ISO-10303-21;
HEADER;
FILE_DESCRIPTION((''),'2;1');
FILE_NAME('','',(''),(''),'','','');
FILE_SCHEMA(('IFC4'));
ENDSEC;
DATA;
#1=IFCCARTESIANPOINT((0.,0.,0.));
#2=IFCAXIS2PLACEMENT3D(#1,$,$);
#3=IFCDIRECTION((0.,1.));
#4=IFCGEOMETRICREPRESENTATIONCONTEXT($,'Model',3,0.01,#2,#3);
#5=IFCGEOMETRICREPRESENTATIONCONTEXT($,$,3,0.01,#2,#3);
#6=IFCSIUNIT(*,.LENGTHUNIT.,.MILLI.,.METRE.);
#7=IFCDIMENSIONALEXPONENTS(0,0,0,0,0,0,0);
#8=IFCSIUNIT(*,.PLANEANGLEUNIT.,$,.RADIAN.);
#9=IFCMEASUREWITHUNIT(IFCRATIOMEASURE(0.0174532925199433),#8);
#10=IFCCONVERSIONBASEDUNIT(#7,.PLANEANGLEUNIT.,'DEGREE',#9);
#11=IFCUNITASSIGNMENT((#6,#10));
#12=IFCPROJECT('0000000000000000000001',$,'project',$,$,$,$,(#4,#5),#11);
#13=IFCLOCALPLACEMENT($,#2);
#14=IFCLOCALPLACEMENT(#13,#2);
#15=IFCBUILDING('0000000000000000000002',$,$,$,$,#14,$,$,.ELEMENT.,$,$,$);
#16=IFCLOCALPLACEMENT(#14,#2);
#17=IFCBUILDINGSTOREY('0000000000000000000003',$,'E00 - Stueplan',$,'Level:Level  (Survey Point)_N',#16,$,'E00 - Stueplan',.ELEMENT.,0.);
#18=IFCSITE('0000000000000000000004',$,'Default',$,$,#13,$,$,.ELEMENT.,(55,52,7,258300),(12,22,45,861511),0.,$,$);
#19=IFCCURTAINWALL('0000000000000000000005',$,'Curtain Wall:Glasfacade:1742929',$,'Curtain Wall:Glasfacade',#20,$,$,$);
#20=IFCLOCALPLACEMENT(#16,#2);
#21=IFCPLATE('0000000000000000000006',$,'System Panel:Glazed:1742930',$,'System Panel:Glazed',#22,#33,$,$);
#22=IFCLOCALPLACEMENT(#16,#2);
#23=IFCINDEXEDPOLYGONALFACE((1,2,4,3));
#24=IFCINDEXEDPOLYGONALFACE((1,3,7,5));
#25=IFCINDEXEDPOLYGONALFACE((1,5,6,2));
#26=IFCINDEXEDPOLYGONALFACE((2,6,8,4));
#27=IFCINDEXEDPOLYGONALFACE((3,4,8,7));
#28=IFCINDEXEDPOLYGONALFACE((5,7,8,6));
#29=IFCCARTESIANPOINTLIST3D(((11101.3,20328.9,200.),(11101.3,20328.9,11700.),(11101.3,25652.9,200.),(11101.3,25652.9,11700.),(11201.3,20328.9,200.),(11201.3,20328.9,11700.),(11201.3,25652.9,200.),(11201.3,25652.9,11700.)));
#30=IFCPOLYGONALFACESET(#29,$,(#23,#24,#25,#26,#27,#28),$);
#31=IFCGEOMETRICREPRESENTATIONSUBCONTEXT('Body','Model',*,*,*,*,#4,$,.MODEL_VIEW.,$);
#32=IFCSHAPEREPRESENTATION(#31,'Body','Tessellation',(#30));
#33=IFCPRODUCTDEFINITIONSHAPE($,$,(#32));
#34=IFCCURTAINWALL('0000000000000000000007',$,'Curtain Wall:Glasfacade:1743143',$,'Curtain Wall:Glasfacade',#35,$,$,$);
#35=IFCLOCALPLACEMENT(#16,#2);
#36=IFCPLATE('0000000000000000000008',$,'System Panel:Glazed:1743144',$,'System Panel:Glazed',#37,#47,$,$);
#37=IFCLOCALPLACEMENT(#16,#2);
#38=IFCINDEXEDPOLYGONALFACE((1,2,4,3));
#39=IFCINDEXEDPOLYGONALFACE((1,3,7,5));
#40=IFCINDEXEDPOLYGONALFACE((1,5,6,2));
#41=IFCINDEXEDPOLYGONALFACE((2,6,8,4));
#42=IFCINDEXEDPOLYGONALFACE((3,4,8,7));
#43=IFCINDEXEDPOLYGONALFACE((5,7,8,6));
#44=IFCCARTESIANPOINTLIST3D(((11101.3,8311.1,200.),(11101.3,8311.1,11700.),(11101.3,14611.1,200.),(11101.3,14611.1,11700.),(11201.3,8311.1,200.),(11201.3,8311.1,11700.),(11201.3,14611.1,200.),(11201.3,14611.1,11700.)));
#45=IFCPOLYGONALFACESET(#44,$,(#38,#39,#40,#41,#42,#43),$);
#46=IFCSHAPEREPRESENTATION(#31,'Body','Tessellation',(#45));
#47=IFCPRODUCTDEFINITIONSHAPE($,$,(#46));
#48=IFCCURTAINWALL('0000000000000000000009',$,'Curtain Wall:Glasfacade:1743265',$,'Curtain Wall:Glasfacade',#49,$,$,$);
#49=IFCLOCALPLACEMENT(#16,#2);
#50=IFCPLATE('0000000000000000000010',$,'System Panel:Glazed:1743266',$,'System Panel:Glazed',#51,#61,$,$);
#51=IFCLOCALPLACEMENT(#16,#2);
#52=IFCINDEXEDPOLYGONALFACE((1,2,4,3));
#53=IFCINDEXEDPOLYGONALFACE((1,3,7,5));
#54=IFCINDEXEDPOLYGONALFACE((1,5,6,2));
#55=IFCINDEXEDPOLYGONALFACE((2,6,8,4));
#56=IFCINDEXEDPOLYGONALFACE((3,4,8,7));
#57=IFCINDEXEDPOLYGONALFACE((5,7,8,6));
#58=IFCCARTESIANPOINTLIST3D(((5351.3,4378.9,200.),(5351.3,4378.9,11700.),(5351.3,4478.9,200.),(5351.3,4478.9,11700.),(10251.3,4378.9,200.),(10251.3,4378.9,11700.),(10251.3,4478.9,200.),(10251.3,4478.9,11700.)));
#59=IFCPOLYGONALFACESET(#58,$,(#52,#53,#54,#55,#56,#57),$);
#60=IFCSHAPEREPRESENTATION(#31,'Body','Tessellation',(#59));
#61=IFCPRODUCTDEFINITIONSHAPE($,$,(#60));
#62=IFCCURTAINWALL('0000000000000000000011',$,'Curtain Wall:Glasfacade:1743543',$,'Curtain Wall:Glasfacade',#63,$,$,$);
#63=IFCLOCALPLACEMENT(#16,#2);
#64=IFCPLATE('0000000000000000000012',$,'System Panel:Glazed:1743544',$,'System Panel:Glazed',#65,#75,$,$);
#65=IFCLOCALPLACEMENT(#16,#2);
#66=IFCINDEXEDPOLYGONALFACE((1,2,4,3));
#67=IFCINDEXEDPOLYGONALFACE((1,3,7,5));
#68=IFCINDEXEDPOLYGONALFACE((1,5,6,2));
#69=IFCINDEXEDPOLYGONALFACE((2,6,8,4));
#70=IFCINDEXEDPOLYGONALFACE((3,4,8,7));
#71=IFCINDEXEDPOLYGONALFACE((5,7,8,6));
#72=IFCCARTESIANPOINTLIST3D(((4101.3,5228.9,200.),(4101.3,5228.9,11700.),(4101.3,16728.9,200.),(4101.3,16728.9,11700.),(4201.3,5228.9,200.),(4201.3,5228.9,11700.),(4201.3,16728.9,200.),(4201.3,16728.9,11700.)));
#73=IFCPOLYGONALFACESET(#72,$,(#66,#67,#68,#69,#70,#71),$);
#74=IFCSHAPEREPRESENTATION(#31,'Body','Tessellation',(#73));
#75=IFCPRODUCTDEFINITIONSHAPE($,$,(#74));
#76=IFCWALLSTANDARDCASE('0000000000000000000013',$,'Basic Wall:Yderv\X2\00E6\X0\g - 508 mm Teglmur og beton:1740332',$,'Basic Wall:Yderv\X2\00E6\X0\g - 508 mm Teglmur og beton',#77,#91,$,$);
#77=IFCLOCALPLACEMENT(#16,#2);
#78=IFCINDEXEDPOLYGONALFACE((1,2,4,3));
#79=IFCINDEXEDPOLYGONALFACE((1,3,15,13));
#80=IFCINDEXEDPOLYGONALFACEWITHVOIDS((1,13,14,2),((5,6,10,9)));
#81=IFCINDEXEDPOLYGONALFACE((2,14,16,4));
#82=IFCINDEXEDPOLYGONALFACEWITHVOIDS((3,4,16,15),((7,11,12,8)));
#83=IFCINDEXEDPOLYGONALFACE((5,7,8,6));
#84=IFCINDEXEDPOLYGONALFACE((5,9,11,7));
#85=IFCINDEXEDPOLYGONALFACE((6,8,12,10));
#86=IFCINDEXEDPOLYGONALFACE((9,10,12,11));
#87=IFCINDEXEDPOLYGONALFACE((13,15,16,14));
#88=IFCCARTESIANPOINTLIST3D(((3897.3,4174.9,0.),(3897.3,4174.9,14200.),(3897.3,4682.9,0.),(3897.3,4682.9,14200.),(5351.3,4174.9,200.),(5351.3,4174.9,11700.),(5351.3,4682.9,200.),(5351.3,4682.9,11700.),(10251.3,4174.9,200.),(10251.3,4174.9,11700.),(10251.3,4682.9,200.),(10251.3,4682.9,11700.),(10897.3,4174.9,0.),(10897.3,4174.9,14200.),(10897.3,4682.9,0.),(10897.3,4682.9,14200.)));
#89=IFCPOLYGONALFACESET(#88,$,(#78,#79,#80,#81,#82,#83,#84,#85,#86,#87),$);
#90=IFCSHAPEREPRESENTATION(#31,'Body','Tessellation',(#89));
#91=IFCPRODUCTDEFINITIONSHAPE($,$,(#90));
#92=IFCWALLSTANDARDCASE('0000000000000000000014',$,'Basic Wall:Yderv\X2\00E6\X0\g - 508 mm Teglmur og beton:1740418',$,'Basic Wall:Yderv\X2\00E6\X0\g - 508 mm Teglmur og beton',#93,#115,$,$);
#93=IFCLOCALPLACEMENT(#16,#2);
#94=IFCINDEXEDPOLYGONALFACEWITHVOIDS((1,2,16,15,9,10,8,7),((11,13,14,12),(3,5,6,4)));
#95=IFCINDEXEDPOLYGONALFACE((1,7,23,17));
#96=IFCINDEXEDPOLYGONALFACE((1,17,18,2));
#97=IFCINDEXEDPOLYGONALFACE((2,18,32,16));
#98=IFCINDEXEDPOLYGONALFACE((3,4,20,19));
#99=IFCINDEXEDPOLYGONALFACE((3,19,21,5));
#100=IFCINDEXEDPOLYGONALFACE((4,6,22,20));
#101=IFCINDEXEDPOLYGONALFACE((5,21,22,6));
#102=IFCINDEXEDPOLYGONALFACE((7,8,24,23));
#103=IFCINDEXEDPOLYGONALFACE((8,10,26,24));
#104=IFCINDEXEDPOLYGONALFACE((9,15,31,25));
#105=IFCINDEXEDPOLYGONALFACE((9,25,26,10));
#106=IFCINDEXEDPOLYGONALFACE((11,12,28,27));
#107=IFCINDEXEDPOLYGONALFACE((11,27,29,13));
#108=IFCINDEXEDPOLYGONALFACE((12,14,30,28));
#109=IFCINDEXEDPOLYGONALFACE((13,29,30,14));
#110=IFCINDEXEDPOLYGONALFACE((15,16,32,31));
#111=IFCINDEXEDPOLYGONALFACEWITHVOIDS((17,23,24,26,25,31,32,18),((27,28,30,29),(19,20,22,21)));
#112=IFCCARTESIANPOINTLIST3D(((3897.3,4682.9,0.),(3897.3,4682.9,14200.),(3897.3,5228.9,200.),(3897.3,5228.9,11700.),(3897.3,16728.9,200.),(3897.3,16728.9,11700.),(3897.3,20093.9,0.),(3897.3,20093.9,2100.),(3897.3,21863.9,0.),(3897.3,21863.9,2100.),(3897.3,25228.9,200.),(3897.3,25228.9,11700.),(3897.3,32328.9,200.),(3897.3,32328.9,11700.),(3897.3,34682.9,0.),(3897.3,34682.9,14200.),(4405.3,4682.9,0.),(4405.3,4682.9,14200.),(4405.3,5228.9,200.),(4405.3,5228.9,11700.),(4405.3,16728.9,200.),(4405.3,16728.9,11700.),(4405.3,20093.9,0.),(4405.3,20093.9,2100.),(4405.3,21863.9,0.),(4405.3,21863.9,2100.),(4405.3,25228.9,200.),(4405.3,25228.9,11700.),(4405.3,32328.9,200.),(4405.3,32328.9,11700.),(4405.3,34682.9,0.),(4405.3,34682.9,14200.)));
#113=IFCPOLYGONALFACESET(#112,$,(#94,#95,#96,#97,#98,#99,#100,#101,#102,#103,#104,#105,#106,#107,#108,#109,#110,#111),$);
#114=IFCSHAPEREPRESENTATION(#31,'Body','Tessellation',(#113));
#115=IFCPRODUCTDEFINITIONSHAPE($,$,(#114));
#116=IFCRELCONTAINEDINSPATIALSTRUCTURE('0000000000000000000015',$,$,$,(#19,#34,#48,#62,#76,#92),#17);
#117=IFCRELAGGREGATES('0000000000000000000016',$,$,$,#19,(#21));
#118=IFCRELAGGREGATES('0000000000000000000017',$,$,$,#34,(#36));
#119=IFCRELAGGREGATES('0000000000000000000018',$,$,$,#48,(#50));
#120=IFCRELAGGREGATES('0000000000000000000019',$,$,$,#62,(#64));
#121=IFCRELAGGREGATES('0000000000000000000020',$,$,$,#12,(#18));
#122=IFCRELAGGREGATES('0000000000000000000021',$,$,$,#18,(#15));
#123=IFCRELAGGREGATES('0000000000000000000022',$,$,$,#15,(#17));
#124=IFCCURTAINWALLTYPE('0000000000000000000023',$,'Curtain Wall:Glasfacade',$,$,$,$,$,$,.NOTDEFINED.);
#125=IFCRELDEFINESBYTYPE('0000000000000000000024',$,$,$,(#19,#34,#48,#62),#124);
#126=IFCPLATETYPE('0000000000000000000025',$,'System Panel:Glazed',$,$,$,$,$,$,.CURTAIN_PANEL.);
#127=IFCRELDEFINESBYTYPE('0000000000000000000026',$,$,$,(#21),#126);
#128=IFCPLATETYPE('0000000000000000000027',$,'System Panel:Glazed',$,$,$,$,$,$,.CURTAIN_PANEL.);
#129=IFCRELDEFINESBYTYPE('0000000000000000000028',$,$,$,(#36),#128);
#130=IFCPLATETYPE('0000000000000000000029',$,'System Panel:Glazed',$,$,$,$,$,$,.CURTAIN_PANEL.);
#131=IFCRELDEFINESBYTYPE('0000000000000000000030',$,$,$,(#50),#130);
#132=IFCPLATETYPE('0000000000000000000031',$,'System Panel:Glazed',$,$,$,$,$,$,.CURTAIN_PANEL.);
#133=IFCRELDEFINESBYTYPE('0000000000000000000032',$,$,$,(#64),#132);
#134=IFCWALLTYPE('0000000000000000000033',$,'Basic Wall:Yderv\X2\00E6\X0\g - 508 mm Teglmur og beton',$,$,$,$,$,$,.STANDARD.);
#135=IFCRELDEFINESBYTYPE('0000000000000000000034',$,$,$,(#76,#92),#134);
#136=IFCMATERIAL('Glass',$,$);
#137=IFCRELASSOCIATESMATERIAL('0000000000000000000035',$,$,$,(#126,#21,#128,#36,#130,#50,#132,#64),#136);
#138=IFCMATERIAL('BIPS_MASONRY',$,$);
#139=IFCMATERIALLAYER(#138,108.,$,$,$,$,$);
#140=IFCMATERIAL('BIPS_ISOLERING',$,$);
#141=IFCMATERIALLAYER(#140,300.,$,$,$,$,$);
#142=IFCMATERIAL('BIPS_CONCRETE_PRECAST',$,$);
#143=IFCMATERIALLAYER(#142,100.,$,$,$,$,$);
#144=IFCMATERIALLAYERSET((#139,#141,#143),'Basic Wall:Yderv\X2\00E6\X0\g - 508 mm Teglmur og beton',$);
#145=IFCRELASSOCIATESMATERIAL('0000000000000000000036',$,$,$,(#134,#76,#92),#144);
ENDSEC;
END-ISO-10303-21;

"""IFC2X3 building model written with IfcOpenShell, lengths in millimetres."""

from ifc_helpers import new_model, entity, si_unit, converted_unit, direction, frame, frame_2d, origin, origin_2d_with_axis, place, context, subcontext, project, spatial, rectangle, extrude, source, transform, mapped, material, layer, layer_set, layer_usage, type_object, type_shapes, element, aggregate, save


model = new_model("IFC2X3")

# Units and contexts
model_context = context("Model", 3, precision=0.01, world=origin(), true_north=direction((0.0, 1.0)))
context_of_model = context(None, 3, precision=0.01, world=origin(), true_north=direction((0.0, 1.0)))
body_context = subcontext(model_context, "Body", "Model", "MODEL_VIEW")
ifc_project = project(units=[si_unit("LENGTHUNIT", "METRE", prefix="MILLI"), converted_unit("PLANEANGLEUNIT", "DEGREE", entity("IfcRatioMeasure", 0.0174532925199433), si_unit("PLANEANGLEUNIT", "RADIAN"), dimensions=[0, 0, 0, 0, 0, 0, 0])], contexts=[model_context, context_of_model])

# Site, building, storey
site_placement = place(None, origin())
site = spatial("IfcSite", under=ifc_project, at=site_placement, Name="Default", CompositionType="ELEMENT", RefLatitude=(55, 52, 7, 258300), RefLongitude=(12, 22, 45, 861511), RefElevation=0.0)
building_placement = place(site_placement, origin())
building = spatial("IfcBuilding", under=site, at=building_placement, CompositionType="ELEMENT")
storey_placement = place(building_placement, origin())
storey = spatial("IfcBuildingStorey", under=building, at=storey_placement, Name="E00 - Stueplan", ObjectType="Level:Level  (Survey Point)_N", LongName="E00 - Stueplan", CompositionType="ELEMENT", Elevation=0.0)

# Curtain walls, plates
curtain_wall_type = type_object("IfcCurtainWallType", Name="Curtain Wall:Glasfacade", PredefinedType="NOTDEFINED")
curtain_wall_1_placement = place(storey_placement, origin())
curtain_wall_1 = element("IfcCurtainWall", 1, at=curtain_wall_1_placement, inside=storey, type_object=curtain_wall_type, Name="Curtain Wall:Glasfacade:1742929", ObjectType="Curtain Wall:Glasfacade")
ifc_material_1 = material(Name="Glass")
plate_type_1 = type_object("IfcPlateType", Name="System Panel:Glazed", PredefinedType="CURTAIN_PANEL", material=ifc_material_1)
shared_shape_1 = source(origin(), body_context, "Body", "SweptSolid", [
    extrude(rectangle(XDim=100.0, YDim=5324.0, at=origin_2d_with_axis()), frame((0.0, 0.0, 0.0), z_axis=(0.0, 0.0, 1.0), x_axis=(0.0, 1.0, 0.0)), (0.0, 0.0, 1.0), 11500.0),
])
type_shapes(plate_type_1, [shared_shape_1])
plate_1_placement = place(curtain_wall_1_placement, frame((11151.3, 22990.9, 200.0), z_axis=(0.0, 0.0, 1.0), x_axis=(0.0, -1.0, 0.0)))
plate_1 = element("IfcPlate", 2, at=plate_1_placement, type_object=plate_type_1, material=ifc_material_1, Name="System Panel:Glazed:1742930", ObjectType="System Panel:Glazed", context=body_context, shape_type="MappedRepresentation", body=[
    mapped(shared_shape_1, transform((0.0, 0.0, 0.0), scale=1.0)),
])
aggregate(curtain_wall_1, [plate_1])
curtain_wall_2_placement = place(storey_placement, origin())
curtain_wall_2 = element("IfcCurtainWall", 3, at=curtain_wall_2_placement, inside=storey, type_object=curtain_wall_type, Name="Curtain Wall:Glasfacade:1743143", ObjectType="Curtain Wall:Glasfacade")
plate_type_2 = type_object("IfcPlateType", Name="System Panel:Glazed", PredefinedType="CURTAIN_PANEL", material=ifc_material_1)
shared_shape_2 = source(origin(), body_context, "Body", "SweptSolid", [
    extrude(rectangle(XDim=100.0, YDim=6300.0, at=origin_2d_with_axis()), frame((0.0, 0.0, 0.0), z_axis=(0.0, 0.0, 1.0), x_axis=(0.0, 1.0, 0.0)), (0.0, 0.0, 1.0), 11500.0),
])
type_shapes(plate_type_2, [shared_shape_2])
plate_2_placement = place(curtain_wall_2_placement, frame((11151.3, 11461.1, 200.0), z_axis=(0.0, 0.0, 1.0), x_axis=(0.0, -1.0, 0.0)))
plate_2 = element("IfcPlate", 4, at=plate_2_placement, type_object=plate_type_2, material=ifc_material_1, Name="System Panel:Glazed:1743144", ObjectType="System Panel:Glazed", context=body_context, shape_type="MappedRepresentation", body=[
    mapped(shared_shape_2, transform((0.0, 0.0, 0.0), scale=1.0)),
])
aggregate(curtain_wall_2, [plate_2])
curtain_wall_3_placement = place(storey_placement, origin())
curtain_wall_3 = element("IfcCurtainWall", 5, at=curtain_wall_3_placement, inside=storey, type_object=curtain_wall_type, Name="Curtain Wall:Glasfacade:1743265", ObjectType="Curtain Wall:Glasfacade")
plate_type_3 = type_object("IfcPlateType", Name="System Panel:Glazed", PredefinedType="CURTAIN_PANEL", material=ifc_material_1)
shared_shape_3 = source(origin(), body_context, "Body", "SweptSolid", [
    extrude(rectangle(XDim=100.0, YDim=4900.0, at=origin_2d_with_axis()), frame((0.0, 0.0, 0.0), z_axis=(0.0, 0.0, 1.0), x_axis=(0.0, 1.0, 0.0)), (0.0, 0.0, 1.0), 11500.0),
])
type_shapes(plate_type_3, [shared_shape_3])
plate_3_placement = place(curtain_wall_3_placement, frame((7801.3, 4428.9, 200.0), z_axis=(0.0, 0.0, 1.0), x_axis=(-1.0, 0.0, 0.0)))
plate_3 = element("IfcPlate", 6, at=plate_3_placement, type_object=plate_type_3, material=ifc_material_1, Name="System Panel:Glazed:1743266", ObjectType="System Panel:Glazed", context=body_context, shape_type="MappedRepresentation", body=[
    mapped(shared_shape_3, transform((0.0, 0.0, 0.0), scale=1.0)),
])
aggregate(curtain_wall_3, [plate_3])
curtain_wall_4_placement = place(storey_placement, origin())
curtain_wall_4 = element("IfcCurtainWall", 7, at=curtain_wall_4_placement, inside=storey, type_object=curtain_wall_type, Name="Curtain Wall:Glasfacade:1743543", ObjectType="Curtain Wall:Glasfacade")
plate_type_4 = type_object("IfcPlateType", Name="System Panel:Glazed", PredefinedType="CURTAIN_PANEL", material=ifc_material_1)
shared_shape_4 = source(origin(), body_context, "Body", "SweptSolid", [
    extrude(rectangle(XDim=100.0, YDim=11500.0, at=origin_2d_with_axis()), frame((0.0, 0.0, 0.0), z_axis=(0.0, 0.0, 1.0), x_axis=(0.0, 1.0, 0.0)), (0.0, 0.0, 1.0), 11500.0),
])
type_shapes(plate_type_4, [shared_shape_4])
plate_4_placement = place(curtain_wall_4_placement, frame((4151.3, 10978.9, 200.0), z_axis=(0.0, 0.0, 1.0), x_axis=(0.0, 1.0, 0.0)))
plate_4 = element("IfcPlate", 8, at=plate_4_placement, type_object=plate_type_4, material=ifc_material_1, Name="System Panel:Glazed:1743544", ObjectType="System Panel:Glazed", context=body_context, shape_type="MappedRepresentation", body=[
    mapped(shared_shape_4, transform((0.0, 0.0, 0.0), scale=1.0)),
])
aggregate(curtain_wall_4, [plate_4])

# Wall, opening
ifc_material_2 = material(Name="BIPS_MASONRY")
ifc_layer_1 = layer(ifc_material_2, 108.0)
ifc_material_3 = material(Name="BIPS_ISOLERING")
ifc_layer_2 = layer(ifc_material_3, 300.0)
ifc_material_4 = material(Name="BIPS_CONCRETE_PRECAST")
ifc_layer_3 = layer(ifc_material_4, 100.0)
ifc_layer_set = layer_set([ifc_layer_1, ifc_layer_2, ifc_layer_3], Name="Basic Wall:Ydervæg - 508 mm Teglmur og beton")
ifc_layer_usage_1 = layer_usage(ifc_layer_set, "AXIS2", "POSITIVE", -254.0)
wall_type = type_object("IfcWallType", Name="Basic Wall:Ydervæg - 508 mm Teglmur og beton", PredefinedType="STANDARD", material=ifc_layer_set)
wall_1_placement = place(storey_placement, frame((10897.3, 4428.9, 0.0), z_axis=(0.0, 0.0, 1.0), x_axis=(-1.0, 0.0, 0.0)))
wall_1 = element("IfcWallStandardCase", 9, at=wall_1_placement, inside=storey, type_object=wall_type, material=ifc_layer_usage_1, Name="Basic Wall:Ydervæg - 508 mm Teglmur og beton:1740332", ObjectType="Basic Wall:Ydervæg - 508 mm Teglmur og beton", context=body_context, shape_type="SweptSolid", body=[
    extrude(rectangle(XDim=7000.0, YDim=508.0, at=frame_2d((3500.0, 0.0), x_axis=(-1.0, 0.0))), origin(), (0.0, 0.0, 1.0), 14200.0),
])
opening_1_placement = place(wall_1_placement, origin())
element("IfcOpeningElement", 10, at=opening_1_placement, cuts=wall_1, ObjectType="Opening", context=body_context, shape_type="SweptSolid", body=[
    extrude(rectangle(XDim=11500.0, YDim=4900.0, at=frame_2d((0.0, 0.0), x_axis=(1.0, 0.0))), frame((3096.0, -406.4, 5950.0), z_axis=(0.0, 1.0, 0.0), x_axis=(0.0, 0.0, 1.0)), (0.0, 0.0, 1.0), 812.8),
])

# Wall, openings
ifc_layer_usage_2 = layer_usage(ifc_layer_set, "AXIS2", "POSITIVE", -254.0)
wall_2_placement = place(storey_placement, frame((4151.3, 4682.9, 0.0), z_axis=(0.0, 0.0, 1.0), x_axis=(0.0, 1.0, 0.0)))
wall_2 = element("IfcWallStandardCase", 11, at=wall_2_placement, inside=storey, type_object=wall_type, material=ifc_layer_usage_2, Name="Basic Wall:Ydervæg - 508 mm Teglmur og beton:1740418", ObjectType="Basic Wall:Ydervæg - 508 mm Teglmur og beton", context=body_context, shape_type="SweptSolid", body=[
    extrude(rectangle(XDim=30000.0, YDim=508.0, at=frame_2d((15000.0, 0.0), x_axis=(-1.0, 0.0))), origin(), (0.0, 0.0, 1.0), 14200.0),
])
opening_2_placement = place(wall_2_placement, origin())
element("IfcOpeningElement", 12, at=opening_2_placement, cuts=wall_2, ObjectType="Opening", context=body_context, shape_type="SweptSolid", body=[
    extrude(rectangle(XDim=11500.0, YDim=11500.0, at=frame_2d((0.0, 0.0), x_axis=(1.0, 0.0))), frame((6296.0, -406.4, 5950.0), z_axis=(0.0, 1.0, 0.0), x_axis=(0.0, 0.0, 1.0)), (0.0, 0.0, 1.0), 812.8),
])
opening_3_placement = place(wall_2_placement, origin())
element("IfcOpeningElement", 13, at=opening_3_placement, cuts=wall_2, ObjectType="Opening", context=body_context, shape_type="SweptSolid", body=[
    extrude(rectangle(XDim=11500.0, YDim=7100.0, at=frame_2d((0.0, 0.0), x_axis=(0.0, 1.0))), frame((24096.0, -406.4, 5950.0), z_axis=(0.0, 1.0, 0.0), x_axis=(-1.0, 0.0, 0.0)), (0.0, 0.0, 1.0), 812.8),
])
opening_4_placement = place(wall_2_placement, frame((17181.0, 254.0, 0.0)))
element("IfcOpeningElement", 14, at=opening_4_placement, cuts=wall_2, ObjectType="Opening", context=body_context, shape_type="SweptSolid", body=[
    extrude(rectangle(XDim=2100.0, YDim=1770.0, at=frame_2d((1050.0, 885.0), x_axis=(1.0, 0.0))), frame((0.0, 0.0, 0.0), z_axis=(0.0, -1.0, 0.0), x_axis=(0.0, 0.0, 1.0)), (0.0, 0.0, 1.0), 508.0),
])

save(model, "model.ifc")
